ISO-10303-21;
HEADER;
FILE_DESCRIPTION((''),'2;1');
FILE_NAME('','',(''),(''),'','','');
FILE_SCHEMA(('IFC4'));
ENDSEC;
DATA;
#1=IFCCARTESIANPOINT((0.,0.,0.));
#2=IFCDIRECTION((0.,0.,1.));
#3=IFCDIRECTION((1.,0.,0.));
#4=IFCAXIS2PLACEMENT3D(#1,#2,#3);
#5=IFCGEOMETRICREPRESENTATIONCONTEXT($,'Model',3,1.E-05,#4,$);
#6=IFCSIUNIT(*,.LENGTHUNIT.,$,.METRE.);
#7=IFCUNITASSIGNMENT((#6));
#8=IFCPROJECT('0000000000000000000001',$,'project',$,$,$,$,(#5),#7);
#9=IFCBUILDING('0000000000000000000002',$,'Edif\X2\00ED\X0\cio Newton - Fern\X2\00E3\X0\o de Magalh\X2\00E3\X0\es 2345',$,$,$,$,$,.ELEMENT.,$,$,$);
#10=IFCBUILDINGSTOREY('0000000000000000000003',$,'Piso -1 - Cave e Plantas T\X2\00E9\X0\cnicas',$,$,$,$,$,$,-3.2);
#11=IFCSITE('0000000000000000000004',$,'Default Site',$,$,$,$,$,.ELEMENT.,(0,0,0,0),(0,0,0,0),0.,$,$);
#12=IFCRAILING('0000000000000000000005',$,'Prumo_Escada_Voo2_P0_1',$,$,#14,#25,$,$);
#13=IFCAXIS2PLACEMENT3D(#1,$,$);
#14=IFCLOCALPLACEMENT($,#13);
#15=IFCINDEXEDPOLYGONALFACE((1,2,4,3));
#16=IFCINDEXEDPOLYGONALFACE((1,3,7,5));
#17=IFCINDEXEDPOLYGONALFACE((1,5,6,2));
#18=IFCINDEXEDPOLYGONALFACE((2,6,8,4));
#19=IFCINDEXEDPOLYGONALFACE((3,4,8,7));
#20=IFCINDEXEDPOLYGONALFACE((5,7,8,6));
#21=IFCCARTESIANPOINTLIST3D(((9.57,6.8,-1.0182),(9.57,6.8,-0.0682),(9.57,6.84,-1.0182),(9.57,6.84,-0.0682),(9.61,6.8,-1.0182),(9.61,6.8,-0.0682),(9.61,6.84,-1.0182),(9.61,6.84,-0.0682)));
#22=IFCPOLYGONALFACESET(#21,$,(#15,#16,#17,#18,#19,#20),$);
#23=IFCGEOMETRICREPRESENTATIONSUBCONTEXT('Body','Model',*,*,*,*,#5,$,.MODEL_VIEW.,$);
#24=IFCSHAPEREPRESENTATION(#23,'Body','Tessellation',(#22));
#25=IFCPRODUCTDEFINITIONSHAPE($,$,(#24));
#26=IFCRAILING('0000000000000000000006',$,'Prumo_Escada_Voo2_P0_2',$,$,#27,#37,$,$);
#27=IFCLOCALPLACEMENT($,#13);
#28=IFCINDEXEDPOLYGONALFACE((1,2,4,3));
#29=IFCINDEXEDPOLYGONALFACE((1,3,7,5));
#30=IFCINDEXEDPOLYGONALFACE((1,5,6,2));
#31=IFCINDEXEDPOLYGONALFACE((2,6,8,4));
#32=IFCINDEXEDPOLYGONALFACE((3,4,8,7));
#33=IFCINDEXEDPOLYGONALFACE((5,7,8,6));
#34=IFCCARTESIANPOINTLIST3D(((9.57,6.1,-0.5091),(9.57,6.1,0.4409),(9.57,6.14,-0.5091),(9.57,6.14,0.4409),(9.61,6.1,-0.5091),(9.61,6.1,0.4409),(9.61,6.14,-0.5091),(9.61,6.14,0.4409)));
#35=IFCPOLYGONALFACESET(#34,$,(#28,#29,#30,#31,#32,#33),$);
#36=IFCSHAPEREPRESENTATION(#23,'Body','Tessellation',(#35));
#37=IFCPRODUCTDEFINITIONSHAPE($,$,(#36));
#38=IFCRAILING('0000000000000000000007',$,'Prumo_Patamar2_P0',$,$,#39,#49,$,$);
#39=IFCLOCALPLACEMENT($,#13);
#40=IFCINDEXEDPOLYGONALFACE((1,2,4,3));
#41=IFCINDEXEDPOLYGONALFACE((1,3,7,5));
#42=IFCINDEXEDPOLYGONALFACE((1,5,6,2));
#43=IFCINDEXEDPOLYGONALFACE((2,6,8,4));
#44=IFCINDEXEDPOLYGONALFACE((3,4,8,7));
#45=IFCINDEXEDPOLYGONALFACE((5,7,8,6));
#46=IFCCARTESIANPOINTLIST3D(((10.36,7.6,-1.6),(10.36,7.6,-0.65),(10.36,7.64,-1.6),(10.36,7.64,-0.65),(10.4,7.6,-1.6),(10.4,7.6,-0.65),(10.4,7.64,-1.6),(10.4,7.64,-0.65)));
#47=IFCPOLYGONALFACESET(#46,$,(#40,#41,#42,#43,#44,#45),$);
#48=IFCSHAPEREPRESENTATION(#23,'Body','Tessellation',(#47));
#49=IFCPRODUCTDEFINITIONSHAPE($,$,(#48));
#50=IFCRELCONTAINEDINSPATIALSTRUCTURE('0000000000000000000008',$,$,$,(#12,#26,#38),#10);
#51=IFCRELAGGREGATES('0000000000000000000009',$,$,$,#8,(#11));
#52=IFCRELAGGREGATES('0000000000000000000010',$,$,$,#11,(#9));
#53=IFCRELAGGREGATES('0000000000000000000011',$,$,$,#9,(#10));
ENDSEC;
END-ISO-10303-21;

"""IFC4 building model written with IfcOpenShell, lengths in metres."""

from ifc_helpers import new_model, si_unit, frame, frame_2d, origin_with_axes, place, context, subcontext, project, spatial, rectangle, extrude, element, save


model = new_model("IFC4")

# Units and contexts
model_context = context("Model", 3, precision=1e-05, world=origin_with_axes())
body_context = subcontext(model_context, "Body", "Model", "MODEL_VIEW")
ifc_project = project(units=[si_unit("LENGTHUNIT", "METRE")], contexts=[model_context])

# Site, building, storey
site = spatial("IfcSite", under=ifc_project, Name="Default Site", CompositionType="ELEMENT", RefLatitude=(0, 0, 0, 0), RefLongitude=(0, 0, 0, 0), RefElevation=0.0)
building = spatial("IfcBuilding", under=site, Name="Edifício Newton - Fernão de Magalhães 2345", CompositionType="ELEMENT")
storey = spatial("IfcBuildingStorey", under=building, Name="Piso -1 - Cave e Plantas Técnicas", Elevation=-3.2)

# Railings
for number, where, z_axis, x_axis, name in (
    (1, (9.57, 6.8, -1.0182), (0.0, 0.0, 1.0), (1.0, 0.0, 0.0), "Prumo_Escada_Voo2_P0_1"),
    (2, (9.57, 6.1, -0.5091), (0.0, 0.0, 1.0), (1.0, 0.0, 0.0), "Prumo_Escada_Voo2_P0_2"),
    (3, (10.36, 7.6, -1.6), (0.0, 0.0, 1.0), (1.0, 0.0, 0.0), "Prumo_Patamar2_P0"),
):
    element("IfcRailing", number, at=place(None, frame(where, z_axis=z_axis, x_axis=x_axis)), inside=storey, Name=name, context=body_context, shape_type="SweptSolid", body=[
        extrude(rectangle(XDim=0.04, YDim=0.04, at=frame_2d((0.02, 0.02))), origin_with_axes(), (0.0, 0.0, 1.0), 0.95),
    ])

save(model, "model.ifc")
